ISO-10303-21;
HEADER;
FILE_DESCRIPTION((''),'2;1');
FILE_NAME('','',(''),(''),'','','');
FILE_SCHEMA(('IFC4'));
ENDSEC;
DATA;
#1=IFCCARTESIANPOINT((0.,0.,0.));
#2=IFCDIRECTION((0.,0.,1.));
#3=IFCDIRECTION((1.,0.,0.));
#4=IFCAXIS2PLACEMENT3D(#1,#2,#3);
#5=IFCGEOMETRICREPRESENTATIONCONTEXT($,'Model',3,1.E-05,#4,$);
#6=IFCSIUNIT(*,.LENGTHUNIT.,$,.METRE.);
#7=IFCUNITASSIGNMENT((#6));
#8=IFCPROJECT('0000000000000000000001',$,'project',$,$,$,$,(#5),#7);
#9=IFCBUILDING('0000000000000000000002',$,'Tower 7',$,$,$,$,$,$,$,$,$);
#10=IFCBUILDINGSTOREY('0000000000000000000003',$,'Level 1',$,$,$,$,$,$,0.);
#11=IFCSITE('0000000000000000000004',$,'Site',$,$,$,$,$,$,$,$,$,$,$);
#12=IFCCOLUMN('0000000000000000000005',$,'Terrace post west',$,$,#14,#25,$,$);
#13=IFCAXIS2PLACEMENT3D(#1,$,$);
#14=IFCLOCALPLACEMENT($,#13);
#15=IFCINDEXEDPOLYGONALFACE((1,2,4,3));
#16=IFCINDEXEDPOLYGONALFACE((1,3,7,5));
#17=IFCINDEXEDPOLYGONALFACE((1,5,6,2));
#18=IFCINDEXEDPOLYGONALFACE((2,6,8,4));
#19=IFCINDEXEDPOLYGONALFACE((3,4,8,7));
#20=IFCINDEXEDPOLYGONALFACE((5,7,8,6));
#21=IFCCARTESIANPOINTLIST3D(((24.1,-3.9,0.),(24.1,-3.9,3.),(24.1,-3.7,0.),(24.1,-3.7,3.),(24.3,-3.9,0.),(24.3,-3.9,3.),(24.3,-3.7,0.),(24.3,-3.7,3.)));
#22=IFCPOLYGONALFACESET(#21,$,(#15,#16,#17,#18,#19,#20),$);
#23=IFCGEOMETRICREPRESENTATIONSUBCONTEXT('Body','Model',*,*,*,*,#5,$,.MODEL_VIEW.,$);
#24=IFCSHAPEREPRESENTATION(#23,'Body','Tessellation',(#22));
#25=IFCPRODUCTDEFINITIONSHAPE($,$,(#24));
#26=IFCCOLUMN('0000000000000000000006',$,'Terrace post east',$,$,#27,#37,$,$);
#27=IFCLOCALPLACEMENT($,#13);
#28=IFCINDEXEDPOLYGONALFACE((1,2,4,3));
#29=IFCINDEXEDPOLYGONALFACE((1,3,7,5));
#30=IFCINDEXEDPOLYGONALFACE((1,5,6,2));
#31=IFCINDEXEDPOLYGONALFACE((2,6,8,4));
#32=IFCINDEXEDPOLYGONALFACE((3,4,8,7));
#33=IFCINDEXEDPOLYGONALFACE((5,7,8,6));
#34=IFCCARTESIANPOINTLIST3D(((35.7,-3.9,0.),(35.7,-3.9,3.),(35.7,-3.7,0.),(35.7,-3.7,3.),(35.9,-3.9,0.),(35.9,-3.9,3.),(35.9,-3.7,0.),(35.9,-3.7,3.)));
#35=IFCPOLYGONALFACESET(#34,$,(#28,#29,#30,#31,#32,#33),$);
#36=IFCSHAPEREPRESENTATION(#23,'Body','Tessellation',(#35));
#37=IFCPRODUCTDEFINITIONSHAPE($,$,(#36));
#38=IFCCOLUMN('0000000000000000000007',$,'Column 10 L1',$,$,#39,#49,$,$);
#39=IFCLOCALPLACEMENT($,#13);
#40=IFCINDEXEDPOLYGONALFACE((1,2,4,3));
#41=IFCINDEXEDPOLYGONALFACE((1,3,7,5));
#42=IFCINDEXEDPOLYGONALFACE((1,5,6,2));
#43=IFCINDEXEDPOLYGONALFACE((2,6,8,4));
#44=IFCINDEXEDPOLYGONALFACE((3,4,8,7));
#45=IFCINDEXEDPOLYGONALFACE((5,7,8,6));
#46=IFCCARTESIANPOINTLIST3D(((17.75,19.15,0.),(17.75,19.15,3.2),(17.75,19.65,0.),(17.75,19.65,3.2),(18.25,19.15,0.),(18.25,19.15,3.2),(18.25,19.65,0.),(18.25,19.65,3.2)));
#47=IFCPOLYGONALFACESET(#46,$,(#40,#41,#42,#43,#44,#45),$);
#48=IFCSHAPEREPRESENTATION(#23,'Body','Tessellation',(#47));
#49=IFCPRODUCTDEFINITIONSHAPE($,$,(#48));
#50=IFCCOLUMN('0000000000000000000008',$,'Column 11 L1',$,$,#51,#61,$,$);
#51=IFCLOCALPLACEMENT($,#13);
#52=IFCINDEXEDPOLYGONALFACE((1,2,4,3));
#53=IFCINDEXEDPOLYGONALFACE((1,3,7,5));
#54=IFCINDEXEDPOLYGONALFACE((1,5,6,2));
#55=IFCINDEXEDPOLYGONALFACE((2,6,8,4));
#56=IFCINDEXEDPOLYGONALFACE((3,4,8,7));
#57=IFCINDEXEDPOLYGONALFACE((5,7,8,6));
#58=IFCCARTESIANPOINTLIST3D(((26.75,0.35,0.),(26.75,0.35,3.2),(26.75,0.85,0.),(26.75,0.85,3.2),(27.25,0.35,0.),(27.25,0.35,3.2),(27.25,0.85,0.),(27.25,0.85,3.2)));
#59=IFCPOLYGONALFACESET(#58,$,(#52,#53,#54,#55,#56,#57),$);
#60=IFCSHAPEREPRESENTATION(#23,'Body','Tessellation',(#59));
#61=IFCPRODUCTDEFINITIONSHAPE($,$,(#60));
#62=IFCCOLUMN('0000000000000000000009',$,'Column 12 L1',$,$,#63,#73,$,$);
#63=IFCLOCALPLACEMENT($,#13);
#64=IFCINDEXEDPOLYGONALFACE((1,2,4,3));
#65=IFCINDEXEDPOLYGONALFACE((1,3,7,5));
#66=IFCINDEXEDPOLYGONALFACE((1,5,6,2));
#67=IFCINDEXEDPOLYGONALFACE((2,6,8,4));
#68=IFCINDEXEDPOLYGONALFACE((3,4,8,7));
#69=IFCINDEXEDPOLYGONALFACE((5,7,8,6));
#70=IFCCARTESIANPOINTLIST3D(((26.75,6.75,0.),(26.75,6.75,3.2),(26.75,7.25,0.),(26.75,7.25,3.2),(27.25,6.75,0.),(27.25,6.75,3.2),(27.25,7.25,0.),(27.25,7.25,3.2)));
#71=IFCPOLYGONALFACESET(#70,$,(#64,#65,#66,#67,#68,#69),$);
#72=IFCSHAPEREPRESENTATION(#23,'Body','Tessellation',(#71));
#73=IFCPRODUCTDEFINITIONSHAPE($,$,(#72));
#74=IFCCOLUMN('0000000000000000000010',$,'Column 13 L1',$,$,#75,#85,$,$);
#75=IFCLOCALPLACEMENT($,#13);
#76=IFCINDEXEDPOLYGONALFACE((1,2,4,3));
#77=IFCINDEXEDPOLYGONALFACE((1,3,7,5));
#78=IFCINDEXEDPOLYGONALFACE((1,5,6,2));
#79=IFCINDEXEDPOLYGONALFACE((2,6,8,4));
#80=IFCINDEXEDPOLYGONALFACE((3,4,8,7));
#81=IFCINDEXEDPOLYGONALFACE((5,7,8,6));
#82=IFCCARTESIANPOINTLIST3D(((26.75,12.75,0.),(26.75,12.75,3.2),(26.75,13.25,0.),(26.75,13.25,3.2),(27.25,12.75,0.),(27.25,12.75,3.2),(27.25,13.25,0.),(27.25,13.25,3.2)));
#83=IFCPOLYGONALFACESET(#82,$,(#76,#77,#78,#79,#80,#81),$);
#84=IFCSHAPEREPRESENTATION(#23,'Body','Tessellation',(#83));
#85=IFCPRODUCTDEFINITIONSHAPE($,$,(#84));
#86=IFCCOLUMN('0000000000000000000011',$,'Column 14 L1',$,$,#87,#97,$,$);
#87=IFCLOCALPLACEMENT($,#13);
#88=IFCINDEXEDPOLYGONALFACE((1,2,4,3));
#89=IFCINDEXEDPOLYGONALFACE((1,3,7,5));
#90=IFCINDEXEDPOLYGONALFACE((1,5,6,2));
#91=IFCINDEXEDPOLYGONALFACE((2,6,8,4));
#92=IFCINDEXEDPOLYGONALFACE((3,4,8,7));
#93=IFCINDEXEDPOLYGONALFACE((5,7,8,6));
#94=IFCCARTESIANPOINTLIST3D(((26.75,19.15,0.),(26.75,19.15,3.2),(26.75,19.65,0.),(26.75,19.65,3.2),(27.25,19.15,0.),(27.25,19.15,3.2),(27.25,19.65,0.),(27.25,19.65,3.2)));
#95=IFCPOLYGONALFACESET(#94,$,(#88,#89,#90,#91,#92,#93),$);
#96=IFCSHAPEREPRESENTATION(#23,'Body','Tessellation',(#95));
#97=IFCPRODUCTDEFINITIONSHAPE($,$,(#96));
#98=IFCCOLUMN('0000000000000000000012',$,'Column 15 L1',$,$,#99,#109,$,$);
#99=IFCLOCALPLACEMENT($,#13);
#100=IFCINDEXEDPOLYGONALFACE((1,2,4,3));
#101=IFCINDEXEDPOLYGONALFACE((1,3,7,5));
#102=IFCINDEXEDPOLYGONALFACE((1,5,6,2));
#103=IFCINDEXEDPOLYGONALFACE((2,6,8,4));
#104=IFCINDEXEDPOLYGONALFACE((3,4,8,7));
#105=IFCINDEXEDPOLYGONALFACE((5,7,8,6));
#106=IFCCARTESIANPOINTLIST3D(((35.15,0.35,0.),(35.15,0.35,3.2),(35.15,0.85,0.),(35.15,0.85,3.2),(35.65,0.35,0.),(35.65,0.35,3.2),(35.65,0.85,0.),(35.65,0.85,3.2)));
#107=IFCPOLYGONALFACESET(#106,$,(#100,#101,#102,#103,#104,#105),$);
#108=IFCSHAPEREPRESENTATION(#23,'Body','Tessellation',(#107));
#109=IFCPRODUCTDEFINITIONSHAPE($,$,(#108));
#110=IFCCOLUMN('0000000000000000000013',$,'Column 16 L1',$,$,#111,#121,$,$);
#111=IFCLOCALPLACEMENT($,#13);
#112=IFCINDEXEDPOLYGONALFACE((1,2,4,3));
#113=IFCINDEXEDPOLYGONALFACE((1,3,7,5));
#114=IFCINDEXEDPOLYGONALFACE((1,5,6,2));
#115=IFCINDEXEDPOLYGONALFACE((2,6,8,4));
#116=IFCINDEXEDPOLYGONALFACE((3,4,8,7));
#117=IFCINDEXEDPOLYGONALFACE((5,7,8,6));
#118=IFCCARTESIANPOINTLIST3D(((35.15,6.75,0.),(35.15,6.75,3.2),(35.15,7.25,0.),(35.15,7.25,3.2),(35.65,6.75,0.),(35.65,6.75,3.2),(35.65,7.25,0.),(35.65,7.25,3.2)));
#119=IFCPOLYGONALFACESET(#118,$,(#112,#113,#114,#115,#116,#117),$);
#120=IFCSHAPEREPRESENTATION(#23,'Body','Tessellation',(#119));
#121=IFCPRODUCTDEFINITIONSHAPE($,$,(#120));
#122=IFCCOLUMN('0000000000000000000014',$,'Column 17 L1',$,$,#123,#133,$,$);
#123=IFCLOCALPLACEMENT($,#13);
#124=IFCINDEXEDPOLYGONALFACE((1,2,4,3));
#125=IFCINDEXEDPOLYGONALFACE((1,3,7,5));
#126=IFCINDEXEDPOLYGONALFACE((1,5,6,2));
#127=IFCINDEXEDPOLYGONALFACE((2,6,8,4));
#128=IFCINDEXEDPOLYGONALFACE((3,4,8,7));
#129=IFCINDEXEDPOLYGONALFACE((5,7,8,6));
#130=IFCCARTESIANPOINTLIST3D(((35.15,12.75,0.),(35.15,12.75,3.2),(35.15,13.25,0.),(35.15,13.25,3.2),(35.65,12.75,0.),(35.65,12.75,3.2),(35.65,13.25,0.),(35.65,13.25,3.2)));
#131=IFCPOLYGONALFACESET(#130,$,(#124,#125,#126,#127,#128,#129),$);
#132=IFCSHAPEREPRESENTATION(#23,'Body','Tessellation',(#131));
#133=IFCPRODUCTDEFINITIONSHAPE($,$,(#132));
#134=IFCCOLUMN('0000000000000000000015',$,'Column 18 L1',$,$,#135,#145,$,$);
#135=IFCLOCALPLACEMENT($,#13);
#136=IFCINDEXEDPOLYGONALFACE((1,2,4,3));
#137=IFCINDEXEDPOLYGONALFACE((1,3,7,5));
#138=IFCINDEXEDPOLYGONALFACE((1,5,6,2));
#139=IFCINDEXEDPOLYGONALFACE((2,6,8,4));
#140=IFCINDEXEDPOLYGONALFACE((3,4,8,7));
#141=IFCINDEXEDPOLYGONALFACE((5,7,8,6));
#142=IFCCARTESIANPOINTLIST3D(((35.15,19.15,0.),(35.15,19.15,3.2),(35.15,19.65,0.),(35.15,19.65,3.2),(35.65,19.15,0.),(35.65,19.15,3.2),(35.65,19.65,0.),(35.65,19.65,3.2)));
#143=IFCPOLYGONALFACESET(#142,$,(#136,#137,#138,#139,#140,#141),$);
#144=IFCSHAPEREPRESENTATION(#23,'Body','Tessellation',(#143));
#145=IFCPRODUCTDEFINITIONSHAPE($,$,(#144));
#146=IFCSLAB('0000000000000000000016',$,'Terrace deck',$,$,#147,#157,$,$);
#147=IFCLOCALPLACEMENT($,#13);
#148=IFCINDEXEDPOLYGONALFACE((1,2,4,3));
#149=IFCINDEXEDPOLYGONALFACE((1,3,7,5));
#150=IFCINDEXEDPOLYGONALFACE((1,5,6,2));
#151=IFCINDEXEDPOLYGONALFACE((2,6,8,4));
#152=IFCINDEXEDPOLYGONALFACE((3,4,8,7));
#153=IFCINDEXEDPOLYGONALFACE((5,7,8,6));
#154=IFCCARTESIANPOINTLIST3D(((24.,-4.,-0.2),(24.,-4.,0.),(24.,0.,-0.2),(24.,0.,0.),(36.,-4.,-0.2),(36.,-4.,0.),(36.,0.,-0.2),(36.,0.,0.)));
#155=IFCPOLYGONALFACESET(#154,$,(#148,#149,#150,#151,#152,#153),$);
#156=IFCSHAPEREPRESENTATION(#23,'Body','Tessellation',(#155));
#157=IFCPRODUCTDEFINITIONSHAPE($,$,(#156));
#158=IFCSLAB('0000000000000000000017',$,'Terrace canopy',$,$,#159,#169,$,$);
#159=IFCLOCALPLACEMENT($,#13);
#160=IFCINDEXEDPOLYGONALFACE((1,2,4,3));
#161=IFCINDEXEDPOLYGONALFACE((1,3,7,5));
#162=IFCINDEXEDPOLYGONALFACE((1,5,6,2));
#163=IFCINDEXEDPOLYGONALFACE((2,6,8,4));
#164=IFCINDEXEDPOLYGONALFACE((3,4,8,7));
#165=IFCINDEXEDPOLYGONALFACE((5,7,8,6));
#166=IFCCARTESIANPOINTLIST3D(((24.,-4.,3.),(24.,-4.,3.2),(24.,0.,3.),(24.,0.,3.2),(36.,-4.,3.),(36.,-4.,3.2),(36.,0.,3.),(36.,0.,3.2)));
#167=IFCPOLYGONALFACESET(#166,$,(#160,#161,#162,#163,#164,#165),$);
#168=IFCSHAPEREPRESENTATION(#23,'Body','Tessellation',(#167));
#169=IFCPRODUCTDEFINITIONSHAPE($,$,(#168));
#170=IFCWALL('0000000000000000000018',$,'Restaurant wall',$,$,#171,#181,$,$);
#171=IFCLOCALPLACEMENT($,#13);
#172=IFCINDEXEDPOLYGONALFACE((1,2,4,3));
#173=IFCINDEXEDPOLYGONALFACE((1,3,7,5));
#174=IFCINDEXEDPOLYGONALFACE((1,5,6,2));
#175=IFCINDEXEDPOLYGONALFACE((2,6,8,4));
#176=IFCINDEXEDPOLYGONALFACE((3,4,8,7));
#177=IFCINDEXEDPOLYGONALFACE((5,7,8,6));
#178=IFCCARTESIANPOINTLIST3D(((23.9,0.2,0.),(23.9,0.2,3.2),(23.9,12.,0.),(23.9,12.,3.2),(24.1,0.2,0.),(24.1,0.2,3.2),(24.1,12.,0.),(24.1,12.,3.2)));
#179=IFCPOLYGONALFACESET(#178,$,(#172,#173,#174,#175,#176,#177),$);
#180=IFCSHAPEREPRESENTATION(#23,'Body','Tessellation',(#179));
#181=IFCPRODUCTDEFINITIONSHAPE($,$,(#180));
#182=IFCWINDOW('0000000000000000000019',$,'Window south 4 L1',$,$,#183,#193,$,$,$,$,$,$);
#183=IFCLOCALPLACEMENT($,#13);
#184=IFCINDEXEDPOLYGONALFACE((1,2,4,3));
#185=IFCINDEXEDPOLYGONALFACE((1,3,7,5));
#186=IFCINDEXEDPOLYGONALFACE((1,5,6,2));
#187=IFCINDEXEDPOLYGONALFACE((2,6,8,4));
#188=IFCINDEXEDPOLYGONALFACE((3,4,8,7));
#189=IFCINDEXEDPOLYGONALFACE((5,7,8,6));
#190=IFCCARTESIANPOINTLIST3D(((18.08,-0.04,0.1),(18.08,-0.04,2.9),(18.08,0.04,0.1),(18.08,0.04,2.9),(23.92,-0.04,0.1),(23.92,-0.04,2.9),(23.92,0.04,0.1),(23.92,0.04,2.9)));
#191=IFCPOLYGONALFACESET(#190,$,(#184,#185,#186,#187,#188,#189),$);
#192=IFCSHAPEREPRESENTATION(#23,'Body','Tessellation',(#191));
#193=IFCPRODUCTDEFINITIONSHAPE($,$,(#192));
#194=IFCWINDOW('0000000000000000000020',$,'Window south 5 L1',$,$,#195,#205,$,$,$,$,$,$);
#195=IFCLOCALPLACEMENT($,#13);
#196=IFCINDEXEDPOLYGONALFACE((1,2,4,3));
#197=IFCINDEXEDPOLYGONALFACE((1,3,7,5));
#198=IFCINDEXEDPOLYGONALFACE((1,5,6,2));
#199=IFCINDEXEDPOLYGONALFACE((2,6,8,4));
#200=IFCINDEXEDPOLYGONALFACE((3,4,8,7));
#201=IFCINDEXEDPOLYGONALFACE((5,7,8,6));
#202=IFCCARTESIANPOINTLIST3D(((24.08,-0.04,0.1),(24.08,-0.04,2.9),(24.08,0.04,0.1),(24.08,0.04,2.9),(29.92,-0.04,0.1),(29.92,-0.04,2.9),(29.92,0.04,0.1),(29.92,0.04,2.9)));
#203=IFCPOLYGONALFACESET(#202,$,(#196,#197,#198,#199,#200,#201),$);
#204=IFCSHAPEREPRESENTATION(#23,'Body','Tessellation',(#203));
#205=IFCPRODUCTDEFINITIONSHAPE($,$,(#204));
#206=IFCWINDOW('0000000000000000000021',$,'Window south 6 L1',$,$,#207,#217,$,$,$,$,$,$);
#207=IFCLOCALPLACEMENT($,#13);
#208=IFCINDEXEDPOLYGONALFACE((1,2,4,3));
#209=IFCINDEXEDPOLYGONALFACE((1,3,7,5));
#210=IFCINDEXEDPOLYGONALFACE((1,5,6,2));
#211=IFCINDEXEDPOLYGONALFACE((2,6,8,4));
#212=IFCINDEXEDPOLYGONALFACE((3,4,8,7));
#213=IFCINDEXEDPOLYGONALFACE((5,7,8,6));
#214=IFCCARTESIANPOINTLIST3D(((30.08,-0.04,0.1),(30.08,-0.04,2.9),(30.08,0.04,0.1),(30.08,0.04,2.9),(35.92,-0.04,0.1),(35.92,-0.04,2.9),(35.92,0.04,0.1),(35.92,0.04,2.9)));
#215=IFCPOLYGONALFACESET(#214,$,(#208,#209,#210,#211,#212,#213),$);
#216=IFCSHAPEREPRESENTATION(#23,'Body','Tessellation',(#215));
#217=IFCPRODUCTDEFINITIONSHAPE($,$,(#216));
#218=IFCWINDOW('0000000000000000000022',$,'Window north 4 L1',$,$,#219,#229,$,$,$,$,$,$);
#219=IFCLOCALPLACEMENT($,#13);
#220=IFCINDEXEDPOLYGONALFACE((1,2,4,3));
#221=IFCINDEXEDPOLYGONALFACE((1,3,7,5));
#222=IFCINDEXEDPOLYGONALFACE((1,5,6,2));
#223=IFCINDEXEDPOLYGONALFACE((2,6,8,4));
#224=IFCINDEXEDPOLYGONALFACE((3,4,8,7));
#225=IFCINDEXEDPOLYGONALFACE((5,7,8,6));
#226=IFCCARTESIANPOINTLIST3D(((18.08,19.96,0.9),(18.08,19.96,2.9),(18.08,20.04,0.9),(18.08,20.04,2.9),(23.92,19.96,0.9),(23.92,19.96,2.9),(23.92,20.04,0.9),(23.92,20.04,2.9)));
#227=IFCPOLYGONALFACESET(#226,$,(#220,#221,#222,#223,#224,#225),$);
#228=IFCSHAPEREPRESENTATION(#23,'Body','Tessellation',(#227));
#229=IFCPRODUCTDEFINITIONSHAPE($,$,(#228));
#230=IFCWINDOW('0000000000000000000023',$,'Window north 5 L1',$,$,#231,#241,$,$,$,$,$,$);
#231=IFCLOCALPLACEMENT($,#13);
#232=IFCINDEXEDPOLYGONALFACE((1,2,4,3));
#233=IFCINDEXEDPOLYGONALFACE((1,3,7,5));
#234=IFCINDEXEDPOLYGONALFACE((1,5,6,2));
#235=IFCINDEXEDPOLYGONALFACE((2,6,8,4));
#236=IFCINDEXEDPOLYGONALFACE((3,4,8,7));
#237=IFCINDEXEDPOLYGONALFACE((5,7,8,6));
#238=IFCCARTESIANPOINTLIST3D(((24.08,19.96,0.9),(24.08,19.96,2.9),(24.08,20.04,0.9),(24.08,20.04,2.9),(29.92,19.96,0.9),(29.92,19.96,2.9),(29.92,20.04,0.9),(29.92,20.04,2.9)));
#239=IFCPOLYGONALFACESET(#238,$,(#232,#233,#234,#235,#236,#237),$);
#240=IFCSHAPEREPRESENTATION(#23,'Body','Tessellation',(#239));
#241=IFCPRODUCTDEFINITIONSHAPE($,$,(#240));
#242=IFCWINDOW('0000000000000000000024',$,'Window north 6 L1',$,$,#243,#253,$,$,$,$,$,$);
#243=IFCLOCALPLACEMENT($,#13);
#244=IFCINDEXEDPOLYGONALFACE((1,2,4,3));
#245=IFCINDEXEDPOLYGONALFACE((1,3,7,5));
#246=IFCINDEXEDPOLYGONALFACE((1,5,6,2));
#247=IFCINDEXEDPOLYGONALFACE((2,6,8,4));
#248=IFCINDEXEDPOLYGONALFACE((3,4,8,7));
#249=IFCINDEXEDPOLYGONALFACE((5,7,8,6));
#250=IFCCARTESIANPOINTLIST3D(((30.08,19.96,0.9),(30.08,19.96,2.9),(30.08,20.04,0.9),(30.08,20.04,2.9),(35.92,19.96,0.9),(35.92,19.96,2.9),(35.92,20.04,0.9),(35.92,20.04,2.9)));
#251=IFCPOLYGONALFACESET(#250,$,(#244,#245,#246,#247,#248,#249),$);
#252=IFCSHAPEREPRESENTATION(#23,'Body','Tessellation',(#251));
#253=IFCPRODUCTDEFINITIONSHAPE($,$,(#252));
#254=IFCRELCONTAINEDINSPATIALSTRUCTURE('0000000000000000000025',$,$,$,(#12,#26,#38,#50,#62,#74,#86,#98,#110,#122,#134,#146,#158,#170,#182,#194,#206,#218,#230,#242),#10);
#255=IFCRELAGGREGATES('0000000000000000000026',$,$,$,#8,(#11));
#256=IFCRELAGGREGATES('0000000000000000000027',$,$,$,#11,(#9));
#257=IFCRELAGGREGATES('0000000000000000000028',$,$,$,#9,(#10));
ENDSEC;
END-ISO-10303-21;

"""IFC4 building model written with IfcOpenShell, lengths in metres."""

from ifc_helpers import new_model, si_unit, frame, origin, origin_with_axes, origin_2d, place, context, subcontext, project, spatial, rectangle, extrude, element, save


model = new_model("IFC4")

# Units and contexts
model_context = context("Model", 3, precision=1e-05, world=origin_with_axes())
body_context = subcontext(model_context, "Body", "Model", "MODEL_VIEW")
ifc_project = project(units=[si_unit("LENGTHUNIT", "METRE")], contexts=[model_context])

# Site, building, storey
site = spatial("IfcSite", under=ifc_project, Name="Site")
building = spatial("IfcBuilding", under=site, Name="Tower 7")
storey = spatial("IfcBuildingStorey", under=building, Name="Level 1", Elevation=0.0)

# Columns
column_1_placement = place(None, frame((24.2, -3.8, 0.0), z_axis=(0.0, 0.0, 1.0), x_axis=(1.0, 0.0, 0.0)))
element("IfcColumn", 1, at=column_1_placement, inside=storey, Name="Terrace post west", context=body_context, shape_type="SweptSolid", body=[
    extrude(rectangle(XDim=0.2, YDim=0.2, at=origin_2d()), origin(), (0.0, 0.0, 1.0), 3.0),
])
column_2_placement = place(None, frame((35.8, -3.8, 0.0), z_axis=(0.0, 0.0, 1.0), x_axis=(1.0, 0.0, 0.0)))
element("IfcColumn", 2, at=column_2_placement, inside=storey, Name="Terrace post east", context=body_context, shape_type="SweptSolid", body=[
    extrude(rectangle(XDim=0.2, YDim=0.2, at=origin_2d()), origin(), (0.0, 0.0, 1.0), 3.0),
])
for number, where, z_axis, x_axis, name in (
    (3, (18.0, 19.4, 0.0), (0.0, 0.0, 1.0), (1.0, 0.0, 0.0), "Column 10 L1"),
    (4, (27.0, 0.6, 0.0), (0.0, 0.0, 1.0), (1.0, 0.0, 0.0), "Column 11 L1"),
    (5, (27.0, 7.0, 0.0), (0.0, 0.0, 1.0), (1.0, 0.0, 0.0), "Column 12 L1"),
    (6, (27.0, 13.0, 0.0), (0.0, 0.0, 1.0), (1.0, 0.0, 0.0), "Column 13 L1"),
    (7, (27.0, 19.4, 0.0), (0.0, 0.0, 1.0), (1.0, 0.0, 0.0), "Column 14 L1"),
    (8, (35.4, 0.6, 0.0), (0.0, 0.0, 1.0), (1.0, 0.0, 0.0), "Column 15 L1"),
    (9, (35.4, 7.0, 0.0), (0.0, 0.0, 1.0), (1.0, 0.0, 0.0), "Column 16 L1"),
    (10, (35.4, 13.0, 0.0), (0.0, 0.0, 1.0), (1.0, 0.0, 0.0), "Column 17 L1"),
    (11, (35.4, 19.4, 0.0), (0.0, 0.0, 1.0), (1.0, 0.0, 0.0), "Column 18 L1"),
):
    element("IfcColumn", number, at=place(None, frame(where, z_axis=z_axis, x_axis=x_axis)), inside=storey, Name=name, context=body_context, shape_type="SweptSolid", body=[
        extrude(rectangle(XDim=0.5, YDim=0.5, at=origin_2d()), origin(), (0.0, 0.0, 1.0), 3.2),
    ])

# Slabs
for number, where, z_axis, x_axis, name in (
    (12, (30.0, -2.0, -0.2), (0.0, 0.0, 1.0), (1.0, 0.0, 0.0), "Terrace deck"),
    (13, (30.0, -2.0, 3.0), (0.0, 0.0, 1.0), (1.0, 0.0, 0.0), "Terrace canopy"),
):
    element("IfcSlab", number, at=place(None, frame(where, z_axis=z_axis, x_axis=x_axis)), inside=storey, Name=name, context=body_context, shape_type="SweptSolid", body=[
        extrude(rectangle(XDim=12.0, YDim=4.0, at=origin_2d()), origin(), (0.0, 0.0, 1.0), 0.2),
    ])

# Wall
wall_1_placement = place(None, frame((24.0, 6.1, 0.0), z_axis=(0.0, 0.0, 1.0), x_axis=(1.0, 0.0, 0.0)))
element("IfcWall", 14, at=wall_1_placement, inside=storey, Name="Restaurant wall", context=body_context, shape_type="SweptSolid", body=[
    extrude(rectangle(XDim=0.2, YDim=11.8, at=origin_2d()), origin(), (0.0, 0.0, 1.0), 3.2),
])

# Windows
for number, where, z_axis, x_axis, name in (
    (15, (21.0, 0.0, 0.1), (0.0, 0.0, 1.0), (1.0, 0.0, 0.0), "Window south 4 L1"),
    (16, (27.0, 0.0, 0.1), (0.0, 0.0, 1.0), (1.0, 0.0, 0.0), "Window south 5 L1"),
    (17, (33.0, 0.0, 0.1), (0.0, 0.0, 1.0), (1.0, 0.0, 0.0), "Window south 6 L1"),
):
    element("IfcWindow", number, at=place(None, frame(where, z_axis=z_axis, x_axis=x_axis)), inside=storey, Name=name, context=body_context, shape_type="SweptSolid", body=[
        extrude(rectangle(XDim=5.84, YDim=0.08, at=origin_2d()), origin(), (0.0, 0.0, 1.0), 2.8),
    ])
for number, where, z_axis, x_axis, name in (
    (18, (21.0, 20.0, 0.9), (0.0, 0.0, 1.0), (1.0, 0.0, 0.0), "Window north 4 L1"),
    (19, (27.0, 20.0, 0.9), (0.0, 0.0, 1.0), (1.0, 0.0, 0.0), "Window north 5 L1"),
    (20, (33.0, 20.0, 0.9), (0.0, 0.0, 1.0), (1.0, 0.0, 0.0), "Window north 6 L1"),
):
    element("IfcWindow", number, at=place(None, frame(where, z_axis=z_axis, x_axis=x_axis)), inside=storey, Name=name, context=body_context, shape_type="SweptSolid", body=[
        extrude(rectangle(XDim=5.84, YDim=0.08, at=origin_2d()), origin(), (0.0, 0.0, 1.0), 2.0),
    ])

save(model, "model.ifc")
